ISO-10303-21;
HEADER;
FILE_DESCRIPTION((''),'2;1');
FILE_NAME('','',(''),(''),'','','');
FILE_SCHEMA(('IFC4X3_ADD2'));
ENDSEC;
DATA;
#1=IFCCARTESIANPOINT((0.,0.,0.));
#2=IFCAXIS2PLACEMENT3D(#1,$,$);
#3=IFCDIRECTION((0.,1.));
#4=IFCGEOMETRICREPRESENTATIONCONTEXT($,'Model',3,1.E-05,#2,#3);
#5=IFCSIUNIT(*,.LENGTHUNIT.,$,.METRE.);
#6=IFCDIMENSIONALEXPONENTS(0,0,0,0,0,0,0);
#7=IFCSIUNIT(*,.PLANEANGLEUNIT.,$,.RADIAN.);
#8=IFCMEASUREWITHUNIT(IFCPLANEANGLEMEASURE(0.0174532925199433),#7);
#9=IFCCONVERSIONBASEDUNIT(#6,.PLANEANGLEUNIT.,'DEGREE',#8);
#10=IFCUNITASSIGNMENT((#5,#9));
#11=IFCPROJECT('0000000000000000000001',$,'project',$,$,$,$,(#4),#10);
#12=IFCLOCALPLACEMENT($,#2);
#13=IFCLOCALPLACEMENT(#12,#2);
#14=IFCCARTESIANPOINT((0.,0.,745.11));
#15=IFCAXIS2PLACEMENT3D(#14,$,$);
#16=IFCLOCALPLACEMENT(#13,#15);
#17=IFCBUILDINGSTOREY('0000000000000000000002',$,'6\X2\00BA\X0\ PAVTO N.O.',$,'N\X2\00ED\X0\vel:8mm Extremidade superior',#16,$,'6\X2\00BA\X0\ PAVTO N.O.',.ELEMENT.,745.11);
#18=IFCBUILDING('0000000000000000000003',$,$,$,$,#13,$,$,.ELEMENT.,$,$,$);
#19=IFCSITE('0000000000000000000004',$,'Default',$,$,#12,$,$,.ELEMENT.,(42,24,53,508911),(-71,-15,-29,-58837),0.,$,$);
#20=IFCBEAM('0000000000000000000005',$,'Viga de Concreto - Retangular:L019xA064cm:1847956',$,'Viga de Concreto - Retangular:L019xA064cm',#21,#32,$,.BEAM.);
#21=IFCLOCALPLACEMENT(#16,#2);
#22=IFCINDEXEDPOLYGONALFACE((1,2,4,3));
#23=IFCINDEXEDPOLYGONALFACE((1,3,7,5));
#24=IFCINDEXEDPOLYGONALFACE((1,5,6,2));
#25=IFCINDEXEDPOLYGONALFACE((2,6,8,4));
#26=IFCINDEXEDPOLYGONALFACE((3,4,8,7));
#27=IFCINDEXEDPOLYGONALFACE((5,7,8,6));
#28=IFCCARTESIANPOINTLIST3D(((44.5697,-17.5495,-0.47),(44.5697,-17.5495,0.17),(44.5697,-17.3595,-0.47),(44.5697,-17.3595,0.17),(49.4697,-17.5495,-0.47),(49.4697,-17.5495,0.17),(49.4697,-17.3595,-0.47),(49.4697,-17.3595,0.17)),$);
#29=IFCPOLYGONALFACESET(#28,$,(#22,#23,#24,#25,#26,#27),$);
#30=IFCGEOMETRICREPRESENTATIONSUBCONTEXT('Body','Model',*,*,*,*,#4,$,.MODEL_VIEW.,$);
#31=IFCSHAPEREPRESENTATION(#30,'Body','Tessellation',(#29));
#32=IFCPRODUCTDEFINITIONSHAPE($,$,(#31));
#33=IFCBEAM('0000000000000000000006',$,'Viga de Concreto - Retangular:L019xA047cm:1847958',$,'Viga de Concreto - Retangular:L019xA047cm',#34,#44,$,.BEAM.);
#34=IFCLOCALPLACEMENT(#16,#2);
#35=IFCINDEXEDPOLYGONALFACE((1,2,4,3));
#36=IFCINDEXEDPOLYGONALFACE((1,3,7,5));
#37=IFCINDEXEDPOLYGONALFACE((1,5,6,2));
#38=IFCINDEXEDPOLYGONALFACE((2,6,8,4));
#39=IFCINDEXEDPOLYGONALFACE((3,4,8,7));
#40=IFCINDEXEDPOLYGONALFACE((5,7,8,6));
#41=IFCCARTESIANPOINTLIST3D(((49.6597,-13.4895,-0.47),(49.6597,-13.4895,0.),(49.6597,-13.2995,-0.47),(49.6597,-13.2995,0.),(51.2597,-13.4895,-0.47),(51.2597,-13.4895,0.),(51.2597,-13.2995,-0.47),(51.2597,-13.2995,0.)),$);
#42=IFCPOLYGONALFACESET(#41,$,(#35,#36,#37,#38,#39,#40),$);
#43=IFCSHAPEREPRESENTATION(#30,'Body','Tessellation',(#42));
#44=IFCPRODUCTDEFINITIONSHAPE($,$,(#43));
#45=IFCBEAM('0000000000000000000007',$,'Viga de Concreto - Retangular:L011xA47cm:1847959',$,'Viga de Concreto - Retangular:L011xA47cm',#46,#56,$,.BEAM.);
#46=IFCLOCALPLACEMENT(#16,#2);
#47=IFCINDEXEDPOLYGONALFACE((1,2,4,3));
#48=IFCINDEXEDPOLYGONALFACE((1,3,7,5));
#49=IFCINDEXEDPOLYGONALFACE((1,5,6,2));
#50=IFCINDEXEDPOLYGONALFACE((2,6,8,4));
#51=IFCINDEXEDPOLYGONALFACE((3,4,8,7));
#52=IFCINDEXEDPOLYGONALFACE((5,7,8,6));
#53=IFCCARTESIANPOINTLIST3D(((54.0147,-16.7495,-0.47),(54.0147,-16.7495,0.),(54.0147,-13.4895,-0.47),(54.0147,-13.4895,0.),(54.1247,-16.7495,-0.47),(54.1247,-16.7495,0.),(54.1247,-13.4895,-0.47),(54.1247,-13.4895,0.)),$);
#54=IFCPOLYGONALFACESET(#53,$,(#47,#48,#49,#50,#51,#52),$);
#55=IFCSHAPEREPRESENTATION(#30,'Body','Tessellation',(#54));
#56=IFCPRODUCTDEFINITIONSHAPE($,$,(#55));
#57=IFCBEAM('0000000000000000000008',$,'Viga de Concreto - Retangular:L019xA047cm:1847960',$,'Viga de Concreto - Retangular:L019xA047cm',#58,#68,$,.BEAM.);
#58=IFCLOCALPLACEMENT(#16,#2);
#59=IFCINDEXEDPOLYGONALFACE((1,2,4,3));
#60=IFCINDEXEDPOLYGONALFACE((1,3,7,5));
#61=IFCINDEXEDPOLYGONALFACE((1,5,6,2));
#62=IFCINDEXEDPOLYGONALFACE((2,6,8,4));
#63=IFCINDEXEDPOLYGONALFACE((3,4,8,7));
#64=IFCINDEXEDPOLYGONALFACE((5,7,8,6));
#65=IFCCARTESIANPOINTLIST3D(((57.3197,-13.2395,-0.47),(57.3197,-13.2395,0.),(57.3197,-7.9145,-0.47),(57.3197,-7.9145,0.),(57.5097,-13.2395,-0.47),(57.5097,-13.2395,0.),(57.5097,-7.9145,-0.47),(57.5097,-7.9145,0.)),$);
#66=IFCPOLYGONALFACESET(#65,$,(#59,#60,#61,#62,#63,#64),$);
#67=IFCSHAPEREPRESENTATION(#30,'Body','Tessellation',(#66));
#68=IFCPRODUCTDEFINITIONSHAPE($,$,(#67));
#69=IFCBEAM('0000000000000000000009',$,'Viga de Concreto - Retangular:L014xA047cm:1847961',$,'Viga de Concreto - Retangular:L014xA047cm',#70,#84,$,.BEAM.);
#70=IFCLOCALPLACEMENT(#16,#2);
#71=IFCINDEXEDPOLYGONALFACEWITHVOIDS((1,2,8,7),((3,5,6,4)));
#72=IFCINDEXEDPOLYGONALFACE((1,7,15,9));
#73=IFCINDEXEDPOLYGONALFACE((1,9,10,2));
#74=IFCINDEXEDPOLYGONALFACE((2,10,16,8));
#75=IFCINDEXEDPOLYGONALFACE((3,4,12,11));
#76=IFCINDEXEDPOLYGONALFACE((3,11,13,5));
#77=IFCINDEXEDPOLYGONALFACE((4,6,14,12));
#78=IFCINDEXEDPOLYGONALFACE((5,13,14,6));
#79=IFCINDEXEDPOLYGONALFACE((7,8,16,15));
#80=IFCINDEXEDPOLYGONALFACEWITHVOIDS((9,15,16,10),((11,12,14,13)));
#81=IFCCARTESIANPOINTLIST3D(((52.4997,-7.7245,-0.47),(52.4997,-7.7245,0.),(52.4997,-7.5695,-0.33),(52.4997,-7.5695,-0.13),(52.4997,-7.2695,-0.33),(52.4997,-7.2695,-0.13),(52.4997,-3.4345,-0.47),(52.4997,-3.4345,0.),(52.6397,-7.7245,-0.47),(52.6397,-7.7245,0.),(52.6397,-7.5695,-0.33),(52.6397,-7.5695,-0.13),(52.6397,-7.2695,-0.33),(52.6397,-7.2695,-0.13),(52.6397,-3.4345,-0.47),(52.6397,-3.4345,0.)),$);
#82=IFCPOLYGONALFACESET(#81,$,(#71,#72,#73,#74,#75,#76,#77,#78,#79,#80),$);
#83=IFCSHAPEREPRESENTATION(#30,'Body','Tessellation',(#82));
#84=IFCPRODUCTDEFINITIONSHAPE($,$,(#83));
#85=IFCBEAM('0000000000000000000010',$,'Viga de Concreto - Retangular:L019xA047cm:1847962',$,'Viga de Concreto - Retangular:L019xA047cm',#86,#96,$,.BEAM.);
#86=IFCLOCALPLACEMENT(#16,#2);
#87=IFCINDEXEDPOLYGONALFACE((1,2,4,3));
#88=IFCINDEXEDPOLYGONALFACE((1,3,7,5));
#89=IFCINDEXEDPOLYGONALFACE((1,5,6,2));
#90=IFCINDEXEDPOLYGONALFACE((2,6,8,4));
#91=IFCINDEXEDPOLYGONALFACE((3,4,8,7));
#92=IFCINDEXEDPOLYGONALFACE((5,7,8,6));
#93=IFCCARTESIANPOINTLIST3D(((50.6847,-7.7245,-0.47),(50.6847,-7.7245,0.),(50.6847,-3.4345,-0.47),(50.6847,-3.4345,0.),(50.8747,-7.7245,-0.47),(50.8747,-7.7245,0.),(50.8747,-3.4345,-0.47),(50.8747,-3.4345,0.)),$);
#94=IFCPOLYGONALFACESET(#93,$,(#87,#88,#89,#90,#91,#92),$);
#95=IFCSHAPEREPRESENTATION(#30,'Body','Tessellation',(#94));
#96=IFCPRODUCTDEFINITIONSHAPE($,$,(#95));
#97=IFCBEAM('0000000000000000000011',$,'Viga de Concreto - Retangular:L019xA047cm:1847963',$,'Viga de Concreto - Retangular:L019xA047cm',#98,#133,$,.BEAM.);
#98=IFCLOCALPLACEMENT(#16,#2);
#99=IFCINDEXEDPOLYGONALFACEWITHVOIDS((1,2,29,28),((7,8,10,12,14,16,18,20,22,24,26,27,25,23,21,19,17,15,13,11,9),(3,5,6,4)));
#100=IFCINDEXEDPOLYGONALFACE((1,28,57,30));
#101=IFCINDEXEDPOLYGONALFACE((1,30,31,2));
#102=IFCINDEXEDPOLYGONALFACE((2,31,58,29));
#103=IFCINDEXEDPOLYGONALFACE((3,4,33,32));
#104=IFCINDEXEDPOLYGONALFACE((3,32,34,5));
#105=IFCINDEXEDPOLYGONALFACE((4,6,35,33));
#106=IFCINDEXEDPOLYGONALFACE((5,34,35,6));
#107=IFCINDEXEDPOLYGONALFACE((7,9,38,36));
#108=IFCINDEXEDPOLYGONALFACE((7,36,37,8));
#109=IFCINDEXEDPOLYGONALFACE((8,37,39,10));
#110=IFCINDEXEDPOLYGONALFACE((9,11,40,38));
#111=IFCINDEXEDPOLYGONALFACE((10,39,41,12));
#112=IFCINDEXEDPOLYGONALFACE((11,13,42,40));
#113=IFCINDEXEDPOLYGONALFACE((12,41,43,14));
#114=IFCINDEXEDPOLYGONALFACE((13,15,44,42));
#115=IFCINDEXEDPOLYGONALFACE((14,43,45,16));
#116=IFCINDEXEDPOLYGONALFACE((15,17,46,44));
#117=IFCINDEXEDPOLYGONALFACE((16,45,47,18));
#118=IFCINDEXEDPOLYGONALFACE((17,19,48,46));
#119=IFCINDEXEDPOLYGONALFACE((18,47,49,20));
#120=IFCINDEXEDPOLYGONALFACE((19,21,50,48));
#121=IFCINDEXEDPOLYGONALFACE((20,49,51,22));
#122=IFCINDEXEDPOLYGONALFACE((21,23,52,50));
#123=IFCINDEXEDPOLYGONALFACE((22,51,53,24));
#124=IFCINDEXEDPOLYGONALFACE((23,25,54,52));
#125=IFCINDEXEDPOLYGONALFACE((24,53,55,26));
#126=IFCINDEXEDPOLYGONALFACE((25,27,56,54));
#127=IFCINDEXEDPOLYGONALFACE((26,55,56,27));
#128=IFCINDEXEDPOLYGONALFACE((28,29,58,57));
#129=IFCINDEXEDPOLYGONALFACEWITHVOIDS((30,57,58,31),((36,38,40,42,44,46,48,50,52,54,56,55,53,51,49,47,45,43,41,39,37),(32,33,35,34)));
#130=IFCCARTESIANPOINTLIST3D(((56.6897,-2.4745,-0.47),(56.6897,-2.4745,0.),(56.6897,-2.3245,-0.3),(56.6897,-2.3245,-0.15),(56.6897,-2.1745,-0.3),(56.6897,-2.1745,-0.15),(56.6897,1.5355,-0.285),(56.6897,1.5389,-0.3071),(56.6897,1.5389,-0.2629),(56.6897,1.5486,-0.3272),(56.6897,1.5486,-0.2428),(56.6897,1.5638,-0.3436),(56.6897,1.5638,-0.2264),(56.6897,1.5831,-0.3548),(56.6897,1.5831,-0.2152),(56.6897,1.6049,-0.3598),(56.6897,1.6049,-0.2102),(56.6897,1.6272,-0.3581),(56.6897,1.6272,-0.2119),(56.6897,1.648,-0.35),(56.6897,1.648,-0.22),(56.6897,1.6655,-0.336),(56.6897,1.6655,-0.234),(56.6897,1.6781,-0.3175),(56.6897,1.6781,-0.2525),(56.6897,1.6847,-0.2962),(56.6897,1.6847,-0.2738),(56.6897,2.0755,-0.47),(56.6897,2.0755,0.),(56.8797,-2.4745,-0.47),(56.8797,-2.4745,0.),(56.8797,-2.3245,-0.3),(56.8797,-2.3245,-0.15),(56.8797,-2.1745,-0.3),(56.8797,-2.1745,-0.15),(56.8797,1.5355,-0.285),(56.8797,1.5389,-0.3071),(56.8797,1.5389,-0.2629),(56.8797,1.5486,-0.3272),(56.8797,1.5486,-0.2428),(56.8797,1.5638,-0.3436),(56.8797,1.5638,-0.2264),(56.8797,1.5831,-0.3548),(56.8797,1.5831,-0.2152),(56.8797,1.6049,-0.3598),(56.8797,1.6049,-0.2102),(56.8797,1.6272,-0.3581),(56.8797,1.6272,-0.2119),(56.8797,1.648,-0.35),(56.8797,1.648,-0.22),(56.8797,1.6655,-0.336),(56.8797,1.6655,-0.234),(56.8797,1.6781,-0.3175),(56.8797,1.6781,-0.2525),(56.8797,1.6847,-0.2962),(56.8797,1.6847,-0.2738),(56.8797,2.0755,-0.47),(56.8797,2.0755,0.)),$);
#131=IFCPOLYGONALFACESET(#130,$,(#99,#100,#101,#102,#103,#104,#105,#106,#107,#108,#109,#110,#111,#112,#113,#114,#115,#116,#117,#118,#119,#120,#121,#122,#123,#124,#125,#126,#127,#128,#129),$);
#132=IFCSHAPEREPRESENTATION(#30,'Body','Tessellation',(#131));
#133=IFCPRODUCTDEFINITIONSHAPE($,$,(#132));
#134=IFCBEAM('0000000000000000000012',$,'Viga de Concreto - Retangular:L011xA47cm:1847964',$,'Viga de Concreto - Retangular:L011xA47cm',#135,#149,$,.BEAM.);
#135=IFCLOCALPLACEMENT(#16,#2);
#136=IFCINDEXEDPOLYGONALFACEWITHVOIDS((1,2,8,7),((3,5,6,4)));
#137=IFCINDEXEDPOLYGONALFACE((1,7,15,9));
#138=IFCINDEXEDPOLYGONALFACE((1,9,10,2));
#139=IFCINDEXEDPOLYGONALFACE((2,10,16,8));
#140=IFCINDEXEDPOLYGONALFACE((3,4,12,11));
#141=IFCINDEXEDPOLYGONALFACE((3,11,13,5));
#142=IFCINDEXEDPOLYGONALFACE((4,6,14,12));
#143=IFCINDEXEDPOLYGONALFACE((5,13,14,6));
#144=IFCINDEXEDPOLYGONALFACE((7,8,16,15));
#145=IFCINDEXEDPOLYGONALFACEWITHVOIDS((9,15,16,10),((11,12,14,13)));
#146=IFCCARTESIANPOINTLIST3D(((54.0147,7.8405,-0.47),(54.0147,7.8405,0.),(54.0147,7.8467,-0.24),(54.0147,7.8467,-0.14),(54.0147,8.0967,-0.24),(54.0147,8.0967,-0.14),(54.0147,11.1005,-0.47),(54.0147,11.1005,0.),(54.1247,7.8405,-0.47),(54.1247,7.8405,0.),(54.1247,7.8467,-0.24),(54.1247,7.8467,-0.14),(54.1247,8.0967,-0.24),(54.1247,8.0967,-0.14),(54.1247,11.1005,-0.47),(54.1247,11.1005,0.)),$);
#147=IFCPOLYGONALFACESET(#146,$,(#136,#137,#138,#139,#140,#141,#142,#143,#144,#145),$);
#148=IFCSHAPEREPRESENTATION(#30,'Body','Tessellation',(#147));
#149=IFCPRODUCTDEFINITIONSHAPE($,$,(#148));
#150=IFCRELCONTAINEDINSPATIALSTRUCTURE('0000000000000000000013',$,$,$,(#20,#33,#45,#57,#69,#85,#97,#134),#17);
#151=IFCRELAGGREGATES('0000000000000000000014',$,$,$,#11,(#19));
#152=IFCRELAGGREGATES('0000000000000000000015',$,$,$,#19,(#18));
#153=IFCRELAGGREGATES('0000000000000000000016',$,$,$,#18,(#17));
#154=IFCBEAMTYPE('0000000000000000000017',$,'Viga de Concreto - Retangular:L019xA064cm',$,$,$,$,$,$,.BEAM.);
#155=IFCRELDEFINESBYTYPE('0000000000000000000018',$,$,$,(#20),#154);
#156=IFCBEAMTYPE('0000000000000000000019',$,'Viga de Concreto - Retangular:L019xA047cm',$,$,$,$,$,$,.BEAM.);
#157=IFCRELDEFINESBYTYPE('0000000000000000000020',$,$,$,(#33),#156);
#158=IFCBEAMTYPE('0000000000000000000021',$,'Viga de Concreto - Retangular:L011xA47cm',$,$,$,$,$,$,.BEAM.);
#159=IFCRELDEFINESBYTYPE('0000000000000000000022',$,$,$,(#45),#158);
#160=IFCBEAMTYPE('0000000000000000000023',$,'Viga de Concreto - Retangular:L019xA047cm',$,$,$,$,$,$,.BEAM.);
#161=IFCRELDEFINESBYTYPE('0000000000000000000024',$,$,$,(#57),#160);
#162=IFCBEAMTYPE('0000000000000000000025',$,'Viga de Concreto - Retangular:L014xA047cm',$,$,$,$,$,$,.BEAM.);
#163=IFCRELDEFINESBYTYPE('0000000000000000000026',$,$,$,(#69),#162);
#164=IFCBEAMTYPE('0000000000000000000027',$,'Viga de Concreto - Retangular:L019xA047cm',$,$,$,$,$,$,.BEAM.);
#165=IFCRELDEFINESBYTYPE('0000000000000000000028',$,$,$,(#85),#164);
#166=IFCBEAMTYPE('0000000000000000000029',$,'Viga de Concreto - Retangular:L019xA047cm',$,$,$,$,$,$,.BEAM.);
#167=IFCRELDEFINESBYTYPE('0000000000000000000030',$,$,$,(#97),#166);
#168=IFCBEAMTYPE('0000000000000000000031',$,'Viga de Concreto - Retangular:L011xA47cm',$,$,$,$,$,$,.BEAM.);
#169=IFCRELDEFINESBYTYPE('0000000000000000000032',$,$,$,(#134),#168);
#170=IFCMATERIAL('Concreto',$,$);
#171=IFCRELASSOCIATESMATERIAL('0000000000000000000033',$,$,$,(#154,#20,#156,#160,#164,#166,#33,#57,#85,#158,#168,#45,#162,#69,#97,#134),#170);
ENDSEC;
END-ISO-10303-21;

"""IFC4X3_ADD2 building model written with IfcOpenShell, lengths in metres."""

from ifc_helpers import new_model, entity, si_unit, converted_unit, direction, frame, frame_2d, origin, origin_2d_with_axis, place, context, subcontext, project, spatial, polyline, segment, composite_curve, rectangle, circle, outline, extrude, boolean, source, transform, mapped, material, material_profile, profile_set, profile_usage, type_object, type_shapes, element, save


model = new_model("IFC4X3_ADD2")

# Units and contexts
model_context = context("Model", 3, precision=1e-05, world=origin(), true_north=direction((0.0, 1.0)))
body_context = subcontext(model_context, "Body", "Model", "MODEL_VIEW")
ifc_project = project(units=[si_unit("LENGTHUNIT", "METRE"), converted_unit("PLANEANGLEUNIT", "DEGREE", entity("IfcPlaneAngleMeasure", 0.0174532925199433), si_unit("PLANEANGLEUNIT", "RADIAN"), dimensions=[0, 0, 0, 0, 0, 0, 0])], contexts=[model_context])

# Site, building, storey
site_placement = place(None, origin())
site = spatial("IfcSite", under=ifc_project, at=site_placement, Name="Default", CompositionType="ELEMENT", RefLatitude=(42, 24, 53, 508911), RefLongitude=(-71, -15, -29, -58837), RefElevation=0.0)
building_placement = place(site_placement, origin())
building = spatial("IfcBuilding", under=site, at=building_placement, CompositionType="ELEMENT")
storey_placement = place(building_placement, frame((0.0, 0.0, 745.11)))
storey = spatial("IfcBuildingStorey", under=building, at=storey_placement, Name="6º PAVTO N.O.", ObjectType="Nível:8mm Extremidade superior", LongName="6º PAVTO N.O.", CompositionType="ELEMENT", Elevation=745.11)

# Beams
ifc_material = material(Name="Concreto")
ifc_material_profile_1 = material_profile(ifc_material, rectangle(XDim=0.47, YDim=0.14, at=frame_2d((0.0, 0.0), x_axis=(0.0, 1.0))), Name="L014xA047cm")
ifc_profile_set_1 = profile_set([ifc_material_profile_1], Name="L014xA047cm")
ifc_material_profile_2 = material_profile(ifc_material, rectangle(XDim=0.64, YDim=0.19, at=frame_2d((0.0, 0.0), x_axis=(1.0, 0.0))), Name="L019xA064cm")
ifc_profile_set_2 = profile_set([ifc_material_profile_2], Name="L019xA064cm")
ifc_profile_usage_1 = profile_usage(ifc_profile_set_2, cardinal=8)
ifc_material_profile_3 = material_profile(ifc_material, rectangle(XDim=0.47, YDim=0.19, at=frame_2d((0.0, 0.0), x_axis=(0.0, 1.0))), Name="L019xA047cm")
ifc_profile_set_3 = profile_set([ifc_material_profile_3], Name="L019xA047cm")
ifc_profile_usage_2 = profile_usage(ifc_profile_set_3, cardinal=8)
beam_type_1 = type_object("IfcBeamType", Name="Viga de Concreto - Retangular:L019xA064cm", PredefinedType="BEAM", material=ifc_profile_set_2)
shared_shape_1 = source(origin(), body_context, "Body", "SweptSolid", [
    extrude(rectangle(XDim=0.64, YDim=0.19, at=frame_2d((0.0, 0.0), x_axis=(1.0, 0.0))), frame((49.4697, -17.4545, 744.96), z_axis=(-1.0, 0.0, 0.0), x_axis=(0.0, 0.0, -1.0)), (0.0, 0.0, 1.0), 4.9),
])
type_shapes(beam_type_1, [shared_shape_1])
beam_1_placement = place(storey_placement, frame((0.0, 0.0, -745.11)))
element("IfcBeam", 1, at=beam_1_placement, inside=storey, type_object=beam_type_1, material=ifc_profile_usage_1, Name="Viga de Concreto - Retangular:L019xA064cm:1847956", ObjectType="Viga de Concreto - Retangular:L019xA064cm", PredefinedType="BEAM", context=body_context, shape_type="MappedRepresentation", body=[
    mapped(shared_shape_1, transform((0.0, 0.0, 0.0), scale=1.0)),
])
beam_type_2 = type_object("IfcBeamType", Name="Viga de Concreto - Retangular:L019xA047cm", PredefinedType="BEAM", material=ifc_profile_set_3)
shared_shape_2 = source(origin(), body_context, "Body", "SweptSolid", [
    extrude(rectangle(XDim=0.47, YDim=0.19, at=frame_2d((0.0, 0.0), x_axis=(1.0, 0.0))), frame((51.2597, -13.3945, 744.875), z_axis=(-1.0, 0.0, 0.0), x_axis=(0.0, 0.0, -1.0)), (0.0, 0.0, 1.0), 1.6),
])
type_shapes(beam_type_2, [shared_shape_2])
beam_2_placement = place(storey_placement, frame((0.0, 0.0, -745.11)))
element("IfcBeam", 2, at=beam_2_placement, inside=storey, type_object=beam_type_2, material=ifc_profile_usage_2, Name="Viga de Concreto - Retangular:L019xA047cm:1847958", ObjectType="Viga de Concreto - Retangular:L019xA047cm", PredefinedType="BEAM", context=body_context, shape_type="MappedRepresentation", body=[
    mapped(shared_shape_2, transform((0.0, 0.0, 0.0), scale=1.0)),
])
ifc_material_profile_4 = material_profile(ifc_material, outline(composite_curve([segment(polyline([(-0.055, 0.235, 0.0), (0.055, 0.235, 0.0)]), True, "CONTINUOUS"), segment(polyline([(0.055, 0.235, 0.0), (0.055, -0.235, 0.0)]), True, "CONTINUOUS"), segment(polyline([(0.055, -0.235, 0.0), (-0.055, -0.235, 0.0)]), True, "CONTINUOUS"), segment(polyline([(-0.055, -0.235, 0.0), (-0.055, 0.235, 0.0)]), True, "CONTINUOUS")], self_intersect=False), kind="CURVE"), Name="L011xA47cm")
ifc_material_profile_5 = material_profile(ifc_material, outline(composite_curve([segment(polyline([(1.6775, -0.055, -0.235), (1.6775, -0.055, 0.235)]), True, "CONTINUOUS"), segment(polyline([(1.6775, -0.055, 0.235), (-1.6775, -0.055, 0.235)]), True, "CONTINUOUS"), segment(polyline([(-1.6775, -0.055, 0.235), (-1.6775, -0.055, -0.235)]), True, "CONTINUOUS"), segment(polyline([(-1.6775, -0.055, -0.235), (1.6775, -0.055, -0.235)]), True, "CONTINUOUS")], self_intersect=False), kind="CURVE"), Name="L011xA47cm")
ifc_profile_set_4 = profile_set([ifc_material_profile_4, ifc_material_profile_5], Name="L011xA47cm")
ifc_profile_usage_3 = profile_usage(ifc_profile_set_4, cardinal=8)
beam_type_3 = type_object("IfcBeamType", Name="Viga de Concreto - Retangular:L011xA47cm", PredefinedType="BEAM", material=ifc_profile_set_4)
shared_shape_3 = source(origin(), body_context, "Body", "SweptSolid", [
    extrude(rectangle(XDim=0.47, YDim=0.11, at=frame_2d((0.0, 0.0), x_axis=(0.0, 1.0))), frame((54.0697, -16.7495, 744.875), z_axis=(0.0, 1.0, 0.0), x_axis=(-1.0, 0.0, 0.0)), (0.0, 0.0, 1.0), 3.26),
])
type_shapes(beam_type_3, [shared_shape_3])
beam_3_placement = place(storey_placement, frame((0.0, 0.0, -745.11)))
element("IfcBeam", 3, at=beam_3_placement, inside=storey, type_object=beam_type_3, material=ifc_profile_usage_3, Name="Viga de Concreto - Retangular:L011xA47cm:1847959", ObjectType="Viga de Concreto - Retangular:L011xA47cm", PredefinedType="BEAM", context=body_context, shape_type="MappedRepresentation", body=[
    mapped(shared_shape_3, transform((0.0, 0.0, 0.0), scale=1.0)),
])
beam_type_4 = type_object("IfcBeamType", Name="Viga de Concreto - Retangular:L019xA047cm", PredefinedType="BEAM", material=ifc_profile_set_3)
shared_shape_4 = source(origin(), body_context, "Body", "SweptSolid", [
    extrude(rectangle(XDim=0.47, YDim=0.19, at=frame_2d((0.0, 0.0), x_axis=(0.0, 1.0))), frame((57.4147, -13.2395, 744.875), z_axis=(0.0, 1.0, 0.0), x_axis=(-1.0, 0.0, 0.0)), (0.0, 0.0, 1.0), 5.325),
])
type_shapes(beam_type_4, [shared_shape_4])
beam_4_placement = place(storey_placement, frame((0.0, 0.0, -745.11)))
element("IfcBeam", 4, at=beam_4_placement, inside=storey, type_object=beam_type_4, material=ifc_profile_usage_2, Name="Viga de Concreto - Retangular:L019xA047cm:1847960", ObjectType="Viga de Concreto - Retangular:L019xA047cm", PredefinedType="BEAM", context=body_context, shape_type="MappedRepresentation", body=[
    mapped(shared_shape_4, transform((0.0, 0.0, 0.0), scale=1.0)),
])
beam_type_5 = type_object("IfcBeamType", Name="Viga de Concreto - Retangular:L014xA047cm", PredefinedType="BEAM", material=ifc_profile_set_1)
shared_shape_5 = source(origin(), body_context, "Body", "CSG", [
    boolean("DIFFERENCE", extrude(rectangle(XDim=0.47, YDim=0.14, at=frame_2d((0.0, 0.0), x_axis=(0.0, 1.0))), frame((52.5697, -7.7245, 744.875), z_axis=(0.0, 1.0, 0.0), x_axis=(-1.0, 0.0, 0.0)), (0.0, 0.0, 1.0), 4.29), extrude(rectangle(XDim=0.2, YDim=0.3, at=frame_2d((0.0, 0.0), x_axis=(0.0, 1.0))), frame((52.6397, -7.4195, 744.88), z_axis=(-1.0, 0.0, 0.0), x_axis=(0.0, 1.0, 0.0)), (0.0, 0.0, 1.0), 0.14)),
])
type_shapes(beam_type_5, [shared_shape_5])
beam_5_placement = place(storey_placement, frame((0.0, 0.0, -745.11)))
element("IfcBeam", 5, at=beam_5_placement, inside=storey, type_object=beam_type_5, material=ifc_material, Name="Viga de Concreto - Retangular:L014xA047cm:1847961", ObjectType="Viga de Concreto - Retangular:L014xA047cm", PredefinedType="BEAM", context=body_context, shape_type="MappedRepresentation", body=[
    mapped(shared_shape_5, transform((0.0, 0.0, 0.0), scale=1.0)),
])
beam_type_6 = type_object("IfcBeamType", Name="Viga de Concreto - Retangular:L019xA047cm", PredefinedType="BEAM", material=ifc_profile_set_3)
shared_shape_6 = source(origin(), body_context, "Body", "SweptSolid", [
    extrude(rectangle(XDim=0.47, YDim=0.19, at=frame_2d((0.0, 0.0), x_axis=(0.0, 1.0))), frame((50.7797, -7.7245, 744.875), z_axis=(0.0, 1.0, 0.0), x_axis=(-1.0, 0.0, 0.0)), (0.0, 0.0, 1.0), 4.29),
])
type_shapes(beam_type_6, [shared_shape_6])
beam_6_placement = place(storey_placement, frame((0.0, 0.0, -745.11)))
element("IfcBeam", 6, at=beam_6_placement, inside=storey, type_object=beam_type_6, material=ifc_profile_usage_2, Name="Viga de Concreto - Retangular:L019xA047cm:1847962", ObjectType="Viga de Concreto - Retangular:L019xA047cm", PredefinedType="BEAM", context=body_context, shape_type="MappedRepresentation", body=[
    mapped(shared_shape_6, transform((0.0, 0.0, 0.0), scale=1.0)),
])
beam_type_7 = type_object("IfcBeamType", Name="Viga de Concreto - Retangular:L019xA047cm", PredefinedType="BEAM", material=ifc_profile_set_3)
shared_shape_7 = source(origin(), body_context, "Body", "CSG", [
    boolean("DIFFERENCE", boolean("DIFFERENCE", extrude(rectangle(XDim=0.47, YDim=0.19, at=frame_2d((0.0, 0.0), x_axis=(0.0, 1.0))), frame((56.7847, 2.0755, 744.875), z_axis=(0.0, -1.0, 0.0), x_axis=(-1.0, 0.0, 0.0)), (0.0, 0.0, 1.0), 4.55), extrude(circle(Radius=0.075, at=origin_2d_with_axis()), frame((56.6897, 1.6105, 744.825), z_axis=(1.0, 0.0, 0.0), x_axis=(0.0, -1.0, 0.0)), (0.0, 0.0, 1.0), 0.19)), extrude(rectangle(XDim=0.15, YDim=0.15, at=frame_2d((0.0, 0.0), x_axis=(0.0, 1.0))), frame((56.8797, -2.2495, 744.885), z_axis=(-1.0, 0.0, 0.0), x_axis=(0.0, 1.0, 0.0)), (0.0, 0.0, 1.0), 0.19)),
])
type_shapes(beam_type_7, [shared_shape_7])
beam_7_placement = place(storey_placement, frame((0.0, 0.0, -745.11)))
element("IfcBeam", 7, at=beam_7_placement, inside=storey, type_object=beam_type_7, material=ifc_material, Name="Viga de Concreto - Retangular:L019xA047cm:1847963", ObjectType="Viga de Concreto - Retangular:L019xA047cm", PredefinedType="BEAM", context=body_context, shape_type="MappedRepresentation", body=[
    mapped(shared_shape_7, transform((0.0, 0.0, 0.0), scale=1.0)),
])
beam_type_8 = type_object("IfcBeamType", Name="Viga de Concreto - Retangular:L011xA47cm", PredefinedType="BEAM", material=ifc_profile_set_4)
shared_shape_8 = source(origin(), body_context, "Body", "CSG", [
    boolean("DIFFERENCE", extrude(rectangle(XDim=0.47, YDim=0.11, at=frame_2d((0.0, 0.0), x_axis=(0.0, 1.0))), frame((54.0697, 7.8405, 744.875), z_axis=(0.0, 1.0, 0.0), x_axis=(-1.0, 0.0, 0.0)), (0.0, 0.0, 1.0), 3.26), extrude(rectangle(XDim=0.1, YDim=0.25, at=frame_2d((0.0, 0.0), x_axis=(0.0, 1.0))), frame((54.1247, 7.9717, 744.92), z_axis=(-1.0, 0.0, 0.0), x_axis=(0.0, 1.0, 0.0)), (0.0, 0.0, 1.0), 0.11)),
])
type_shapes(beam_type_8, [shared_shape_8])
beam_8_placement = place(storey_placement, frame((0.0, 0.0, -745.11)))
element("IfcBeam", 8, at=beam_8_placement, inside=storey, type_object=beam_type_8, material=ifc_material, Name="Viga de Concreto - Retangular:L011xA47cm:1847964", ObjectType="Viga de Concreto - Retangular:L011xA47cm", PredefinedType="BEAM", context=body_context, shape_type="MappedRepresentation", body=[
    mapped(shared_shape_8, transform((0.0, 0.0, 0.0), scale=1.0)),
])

save(model, "model.ifc")
